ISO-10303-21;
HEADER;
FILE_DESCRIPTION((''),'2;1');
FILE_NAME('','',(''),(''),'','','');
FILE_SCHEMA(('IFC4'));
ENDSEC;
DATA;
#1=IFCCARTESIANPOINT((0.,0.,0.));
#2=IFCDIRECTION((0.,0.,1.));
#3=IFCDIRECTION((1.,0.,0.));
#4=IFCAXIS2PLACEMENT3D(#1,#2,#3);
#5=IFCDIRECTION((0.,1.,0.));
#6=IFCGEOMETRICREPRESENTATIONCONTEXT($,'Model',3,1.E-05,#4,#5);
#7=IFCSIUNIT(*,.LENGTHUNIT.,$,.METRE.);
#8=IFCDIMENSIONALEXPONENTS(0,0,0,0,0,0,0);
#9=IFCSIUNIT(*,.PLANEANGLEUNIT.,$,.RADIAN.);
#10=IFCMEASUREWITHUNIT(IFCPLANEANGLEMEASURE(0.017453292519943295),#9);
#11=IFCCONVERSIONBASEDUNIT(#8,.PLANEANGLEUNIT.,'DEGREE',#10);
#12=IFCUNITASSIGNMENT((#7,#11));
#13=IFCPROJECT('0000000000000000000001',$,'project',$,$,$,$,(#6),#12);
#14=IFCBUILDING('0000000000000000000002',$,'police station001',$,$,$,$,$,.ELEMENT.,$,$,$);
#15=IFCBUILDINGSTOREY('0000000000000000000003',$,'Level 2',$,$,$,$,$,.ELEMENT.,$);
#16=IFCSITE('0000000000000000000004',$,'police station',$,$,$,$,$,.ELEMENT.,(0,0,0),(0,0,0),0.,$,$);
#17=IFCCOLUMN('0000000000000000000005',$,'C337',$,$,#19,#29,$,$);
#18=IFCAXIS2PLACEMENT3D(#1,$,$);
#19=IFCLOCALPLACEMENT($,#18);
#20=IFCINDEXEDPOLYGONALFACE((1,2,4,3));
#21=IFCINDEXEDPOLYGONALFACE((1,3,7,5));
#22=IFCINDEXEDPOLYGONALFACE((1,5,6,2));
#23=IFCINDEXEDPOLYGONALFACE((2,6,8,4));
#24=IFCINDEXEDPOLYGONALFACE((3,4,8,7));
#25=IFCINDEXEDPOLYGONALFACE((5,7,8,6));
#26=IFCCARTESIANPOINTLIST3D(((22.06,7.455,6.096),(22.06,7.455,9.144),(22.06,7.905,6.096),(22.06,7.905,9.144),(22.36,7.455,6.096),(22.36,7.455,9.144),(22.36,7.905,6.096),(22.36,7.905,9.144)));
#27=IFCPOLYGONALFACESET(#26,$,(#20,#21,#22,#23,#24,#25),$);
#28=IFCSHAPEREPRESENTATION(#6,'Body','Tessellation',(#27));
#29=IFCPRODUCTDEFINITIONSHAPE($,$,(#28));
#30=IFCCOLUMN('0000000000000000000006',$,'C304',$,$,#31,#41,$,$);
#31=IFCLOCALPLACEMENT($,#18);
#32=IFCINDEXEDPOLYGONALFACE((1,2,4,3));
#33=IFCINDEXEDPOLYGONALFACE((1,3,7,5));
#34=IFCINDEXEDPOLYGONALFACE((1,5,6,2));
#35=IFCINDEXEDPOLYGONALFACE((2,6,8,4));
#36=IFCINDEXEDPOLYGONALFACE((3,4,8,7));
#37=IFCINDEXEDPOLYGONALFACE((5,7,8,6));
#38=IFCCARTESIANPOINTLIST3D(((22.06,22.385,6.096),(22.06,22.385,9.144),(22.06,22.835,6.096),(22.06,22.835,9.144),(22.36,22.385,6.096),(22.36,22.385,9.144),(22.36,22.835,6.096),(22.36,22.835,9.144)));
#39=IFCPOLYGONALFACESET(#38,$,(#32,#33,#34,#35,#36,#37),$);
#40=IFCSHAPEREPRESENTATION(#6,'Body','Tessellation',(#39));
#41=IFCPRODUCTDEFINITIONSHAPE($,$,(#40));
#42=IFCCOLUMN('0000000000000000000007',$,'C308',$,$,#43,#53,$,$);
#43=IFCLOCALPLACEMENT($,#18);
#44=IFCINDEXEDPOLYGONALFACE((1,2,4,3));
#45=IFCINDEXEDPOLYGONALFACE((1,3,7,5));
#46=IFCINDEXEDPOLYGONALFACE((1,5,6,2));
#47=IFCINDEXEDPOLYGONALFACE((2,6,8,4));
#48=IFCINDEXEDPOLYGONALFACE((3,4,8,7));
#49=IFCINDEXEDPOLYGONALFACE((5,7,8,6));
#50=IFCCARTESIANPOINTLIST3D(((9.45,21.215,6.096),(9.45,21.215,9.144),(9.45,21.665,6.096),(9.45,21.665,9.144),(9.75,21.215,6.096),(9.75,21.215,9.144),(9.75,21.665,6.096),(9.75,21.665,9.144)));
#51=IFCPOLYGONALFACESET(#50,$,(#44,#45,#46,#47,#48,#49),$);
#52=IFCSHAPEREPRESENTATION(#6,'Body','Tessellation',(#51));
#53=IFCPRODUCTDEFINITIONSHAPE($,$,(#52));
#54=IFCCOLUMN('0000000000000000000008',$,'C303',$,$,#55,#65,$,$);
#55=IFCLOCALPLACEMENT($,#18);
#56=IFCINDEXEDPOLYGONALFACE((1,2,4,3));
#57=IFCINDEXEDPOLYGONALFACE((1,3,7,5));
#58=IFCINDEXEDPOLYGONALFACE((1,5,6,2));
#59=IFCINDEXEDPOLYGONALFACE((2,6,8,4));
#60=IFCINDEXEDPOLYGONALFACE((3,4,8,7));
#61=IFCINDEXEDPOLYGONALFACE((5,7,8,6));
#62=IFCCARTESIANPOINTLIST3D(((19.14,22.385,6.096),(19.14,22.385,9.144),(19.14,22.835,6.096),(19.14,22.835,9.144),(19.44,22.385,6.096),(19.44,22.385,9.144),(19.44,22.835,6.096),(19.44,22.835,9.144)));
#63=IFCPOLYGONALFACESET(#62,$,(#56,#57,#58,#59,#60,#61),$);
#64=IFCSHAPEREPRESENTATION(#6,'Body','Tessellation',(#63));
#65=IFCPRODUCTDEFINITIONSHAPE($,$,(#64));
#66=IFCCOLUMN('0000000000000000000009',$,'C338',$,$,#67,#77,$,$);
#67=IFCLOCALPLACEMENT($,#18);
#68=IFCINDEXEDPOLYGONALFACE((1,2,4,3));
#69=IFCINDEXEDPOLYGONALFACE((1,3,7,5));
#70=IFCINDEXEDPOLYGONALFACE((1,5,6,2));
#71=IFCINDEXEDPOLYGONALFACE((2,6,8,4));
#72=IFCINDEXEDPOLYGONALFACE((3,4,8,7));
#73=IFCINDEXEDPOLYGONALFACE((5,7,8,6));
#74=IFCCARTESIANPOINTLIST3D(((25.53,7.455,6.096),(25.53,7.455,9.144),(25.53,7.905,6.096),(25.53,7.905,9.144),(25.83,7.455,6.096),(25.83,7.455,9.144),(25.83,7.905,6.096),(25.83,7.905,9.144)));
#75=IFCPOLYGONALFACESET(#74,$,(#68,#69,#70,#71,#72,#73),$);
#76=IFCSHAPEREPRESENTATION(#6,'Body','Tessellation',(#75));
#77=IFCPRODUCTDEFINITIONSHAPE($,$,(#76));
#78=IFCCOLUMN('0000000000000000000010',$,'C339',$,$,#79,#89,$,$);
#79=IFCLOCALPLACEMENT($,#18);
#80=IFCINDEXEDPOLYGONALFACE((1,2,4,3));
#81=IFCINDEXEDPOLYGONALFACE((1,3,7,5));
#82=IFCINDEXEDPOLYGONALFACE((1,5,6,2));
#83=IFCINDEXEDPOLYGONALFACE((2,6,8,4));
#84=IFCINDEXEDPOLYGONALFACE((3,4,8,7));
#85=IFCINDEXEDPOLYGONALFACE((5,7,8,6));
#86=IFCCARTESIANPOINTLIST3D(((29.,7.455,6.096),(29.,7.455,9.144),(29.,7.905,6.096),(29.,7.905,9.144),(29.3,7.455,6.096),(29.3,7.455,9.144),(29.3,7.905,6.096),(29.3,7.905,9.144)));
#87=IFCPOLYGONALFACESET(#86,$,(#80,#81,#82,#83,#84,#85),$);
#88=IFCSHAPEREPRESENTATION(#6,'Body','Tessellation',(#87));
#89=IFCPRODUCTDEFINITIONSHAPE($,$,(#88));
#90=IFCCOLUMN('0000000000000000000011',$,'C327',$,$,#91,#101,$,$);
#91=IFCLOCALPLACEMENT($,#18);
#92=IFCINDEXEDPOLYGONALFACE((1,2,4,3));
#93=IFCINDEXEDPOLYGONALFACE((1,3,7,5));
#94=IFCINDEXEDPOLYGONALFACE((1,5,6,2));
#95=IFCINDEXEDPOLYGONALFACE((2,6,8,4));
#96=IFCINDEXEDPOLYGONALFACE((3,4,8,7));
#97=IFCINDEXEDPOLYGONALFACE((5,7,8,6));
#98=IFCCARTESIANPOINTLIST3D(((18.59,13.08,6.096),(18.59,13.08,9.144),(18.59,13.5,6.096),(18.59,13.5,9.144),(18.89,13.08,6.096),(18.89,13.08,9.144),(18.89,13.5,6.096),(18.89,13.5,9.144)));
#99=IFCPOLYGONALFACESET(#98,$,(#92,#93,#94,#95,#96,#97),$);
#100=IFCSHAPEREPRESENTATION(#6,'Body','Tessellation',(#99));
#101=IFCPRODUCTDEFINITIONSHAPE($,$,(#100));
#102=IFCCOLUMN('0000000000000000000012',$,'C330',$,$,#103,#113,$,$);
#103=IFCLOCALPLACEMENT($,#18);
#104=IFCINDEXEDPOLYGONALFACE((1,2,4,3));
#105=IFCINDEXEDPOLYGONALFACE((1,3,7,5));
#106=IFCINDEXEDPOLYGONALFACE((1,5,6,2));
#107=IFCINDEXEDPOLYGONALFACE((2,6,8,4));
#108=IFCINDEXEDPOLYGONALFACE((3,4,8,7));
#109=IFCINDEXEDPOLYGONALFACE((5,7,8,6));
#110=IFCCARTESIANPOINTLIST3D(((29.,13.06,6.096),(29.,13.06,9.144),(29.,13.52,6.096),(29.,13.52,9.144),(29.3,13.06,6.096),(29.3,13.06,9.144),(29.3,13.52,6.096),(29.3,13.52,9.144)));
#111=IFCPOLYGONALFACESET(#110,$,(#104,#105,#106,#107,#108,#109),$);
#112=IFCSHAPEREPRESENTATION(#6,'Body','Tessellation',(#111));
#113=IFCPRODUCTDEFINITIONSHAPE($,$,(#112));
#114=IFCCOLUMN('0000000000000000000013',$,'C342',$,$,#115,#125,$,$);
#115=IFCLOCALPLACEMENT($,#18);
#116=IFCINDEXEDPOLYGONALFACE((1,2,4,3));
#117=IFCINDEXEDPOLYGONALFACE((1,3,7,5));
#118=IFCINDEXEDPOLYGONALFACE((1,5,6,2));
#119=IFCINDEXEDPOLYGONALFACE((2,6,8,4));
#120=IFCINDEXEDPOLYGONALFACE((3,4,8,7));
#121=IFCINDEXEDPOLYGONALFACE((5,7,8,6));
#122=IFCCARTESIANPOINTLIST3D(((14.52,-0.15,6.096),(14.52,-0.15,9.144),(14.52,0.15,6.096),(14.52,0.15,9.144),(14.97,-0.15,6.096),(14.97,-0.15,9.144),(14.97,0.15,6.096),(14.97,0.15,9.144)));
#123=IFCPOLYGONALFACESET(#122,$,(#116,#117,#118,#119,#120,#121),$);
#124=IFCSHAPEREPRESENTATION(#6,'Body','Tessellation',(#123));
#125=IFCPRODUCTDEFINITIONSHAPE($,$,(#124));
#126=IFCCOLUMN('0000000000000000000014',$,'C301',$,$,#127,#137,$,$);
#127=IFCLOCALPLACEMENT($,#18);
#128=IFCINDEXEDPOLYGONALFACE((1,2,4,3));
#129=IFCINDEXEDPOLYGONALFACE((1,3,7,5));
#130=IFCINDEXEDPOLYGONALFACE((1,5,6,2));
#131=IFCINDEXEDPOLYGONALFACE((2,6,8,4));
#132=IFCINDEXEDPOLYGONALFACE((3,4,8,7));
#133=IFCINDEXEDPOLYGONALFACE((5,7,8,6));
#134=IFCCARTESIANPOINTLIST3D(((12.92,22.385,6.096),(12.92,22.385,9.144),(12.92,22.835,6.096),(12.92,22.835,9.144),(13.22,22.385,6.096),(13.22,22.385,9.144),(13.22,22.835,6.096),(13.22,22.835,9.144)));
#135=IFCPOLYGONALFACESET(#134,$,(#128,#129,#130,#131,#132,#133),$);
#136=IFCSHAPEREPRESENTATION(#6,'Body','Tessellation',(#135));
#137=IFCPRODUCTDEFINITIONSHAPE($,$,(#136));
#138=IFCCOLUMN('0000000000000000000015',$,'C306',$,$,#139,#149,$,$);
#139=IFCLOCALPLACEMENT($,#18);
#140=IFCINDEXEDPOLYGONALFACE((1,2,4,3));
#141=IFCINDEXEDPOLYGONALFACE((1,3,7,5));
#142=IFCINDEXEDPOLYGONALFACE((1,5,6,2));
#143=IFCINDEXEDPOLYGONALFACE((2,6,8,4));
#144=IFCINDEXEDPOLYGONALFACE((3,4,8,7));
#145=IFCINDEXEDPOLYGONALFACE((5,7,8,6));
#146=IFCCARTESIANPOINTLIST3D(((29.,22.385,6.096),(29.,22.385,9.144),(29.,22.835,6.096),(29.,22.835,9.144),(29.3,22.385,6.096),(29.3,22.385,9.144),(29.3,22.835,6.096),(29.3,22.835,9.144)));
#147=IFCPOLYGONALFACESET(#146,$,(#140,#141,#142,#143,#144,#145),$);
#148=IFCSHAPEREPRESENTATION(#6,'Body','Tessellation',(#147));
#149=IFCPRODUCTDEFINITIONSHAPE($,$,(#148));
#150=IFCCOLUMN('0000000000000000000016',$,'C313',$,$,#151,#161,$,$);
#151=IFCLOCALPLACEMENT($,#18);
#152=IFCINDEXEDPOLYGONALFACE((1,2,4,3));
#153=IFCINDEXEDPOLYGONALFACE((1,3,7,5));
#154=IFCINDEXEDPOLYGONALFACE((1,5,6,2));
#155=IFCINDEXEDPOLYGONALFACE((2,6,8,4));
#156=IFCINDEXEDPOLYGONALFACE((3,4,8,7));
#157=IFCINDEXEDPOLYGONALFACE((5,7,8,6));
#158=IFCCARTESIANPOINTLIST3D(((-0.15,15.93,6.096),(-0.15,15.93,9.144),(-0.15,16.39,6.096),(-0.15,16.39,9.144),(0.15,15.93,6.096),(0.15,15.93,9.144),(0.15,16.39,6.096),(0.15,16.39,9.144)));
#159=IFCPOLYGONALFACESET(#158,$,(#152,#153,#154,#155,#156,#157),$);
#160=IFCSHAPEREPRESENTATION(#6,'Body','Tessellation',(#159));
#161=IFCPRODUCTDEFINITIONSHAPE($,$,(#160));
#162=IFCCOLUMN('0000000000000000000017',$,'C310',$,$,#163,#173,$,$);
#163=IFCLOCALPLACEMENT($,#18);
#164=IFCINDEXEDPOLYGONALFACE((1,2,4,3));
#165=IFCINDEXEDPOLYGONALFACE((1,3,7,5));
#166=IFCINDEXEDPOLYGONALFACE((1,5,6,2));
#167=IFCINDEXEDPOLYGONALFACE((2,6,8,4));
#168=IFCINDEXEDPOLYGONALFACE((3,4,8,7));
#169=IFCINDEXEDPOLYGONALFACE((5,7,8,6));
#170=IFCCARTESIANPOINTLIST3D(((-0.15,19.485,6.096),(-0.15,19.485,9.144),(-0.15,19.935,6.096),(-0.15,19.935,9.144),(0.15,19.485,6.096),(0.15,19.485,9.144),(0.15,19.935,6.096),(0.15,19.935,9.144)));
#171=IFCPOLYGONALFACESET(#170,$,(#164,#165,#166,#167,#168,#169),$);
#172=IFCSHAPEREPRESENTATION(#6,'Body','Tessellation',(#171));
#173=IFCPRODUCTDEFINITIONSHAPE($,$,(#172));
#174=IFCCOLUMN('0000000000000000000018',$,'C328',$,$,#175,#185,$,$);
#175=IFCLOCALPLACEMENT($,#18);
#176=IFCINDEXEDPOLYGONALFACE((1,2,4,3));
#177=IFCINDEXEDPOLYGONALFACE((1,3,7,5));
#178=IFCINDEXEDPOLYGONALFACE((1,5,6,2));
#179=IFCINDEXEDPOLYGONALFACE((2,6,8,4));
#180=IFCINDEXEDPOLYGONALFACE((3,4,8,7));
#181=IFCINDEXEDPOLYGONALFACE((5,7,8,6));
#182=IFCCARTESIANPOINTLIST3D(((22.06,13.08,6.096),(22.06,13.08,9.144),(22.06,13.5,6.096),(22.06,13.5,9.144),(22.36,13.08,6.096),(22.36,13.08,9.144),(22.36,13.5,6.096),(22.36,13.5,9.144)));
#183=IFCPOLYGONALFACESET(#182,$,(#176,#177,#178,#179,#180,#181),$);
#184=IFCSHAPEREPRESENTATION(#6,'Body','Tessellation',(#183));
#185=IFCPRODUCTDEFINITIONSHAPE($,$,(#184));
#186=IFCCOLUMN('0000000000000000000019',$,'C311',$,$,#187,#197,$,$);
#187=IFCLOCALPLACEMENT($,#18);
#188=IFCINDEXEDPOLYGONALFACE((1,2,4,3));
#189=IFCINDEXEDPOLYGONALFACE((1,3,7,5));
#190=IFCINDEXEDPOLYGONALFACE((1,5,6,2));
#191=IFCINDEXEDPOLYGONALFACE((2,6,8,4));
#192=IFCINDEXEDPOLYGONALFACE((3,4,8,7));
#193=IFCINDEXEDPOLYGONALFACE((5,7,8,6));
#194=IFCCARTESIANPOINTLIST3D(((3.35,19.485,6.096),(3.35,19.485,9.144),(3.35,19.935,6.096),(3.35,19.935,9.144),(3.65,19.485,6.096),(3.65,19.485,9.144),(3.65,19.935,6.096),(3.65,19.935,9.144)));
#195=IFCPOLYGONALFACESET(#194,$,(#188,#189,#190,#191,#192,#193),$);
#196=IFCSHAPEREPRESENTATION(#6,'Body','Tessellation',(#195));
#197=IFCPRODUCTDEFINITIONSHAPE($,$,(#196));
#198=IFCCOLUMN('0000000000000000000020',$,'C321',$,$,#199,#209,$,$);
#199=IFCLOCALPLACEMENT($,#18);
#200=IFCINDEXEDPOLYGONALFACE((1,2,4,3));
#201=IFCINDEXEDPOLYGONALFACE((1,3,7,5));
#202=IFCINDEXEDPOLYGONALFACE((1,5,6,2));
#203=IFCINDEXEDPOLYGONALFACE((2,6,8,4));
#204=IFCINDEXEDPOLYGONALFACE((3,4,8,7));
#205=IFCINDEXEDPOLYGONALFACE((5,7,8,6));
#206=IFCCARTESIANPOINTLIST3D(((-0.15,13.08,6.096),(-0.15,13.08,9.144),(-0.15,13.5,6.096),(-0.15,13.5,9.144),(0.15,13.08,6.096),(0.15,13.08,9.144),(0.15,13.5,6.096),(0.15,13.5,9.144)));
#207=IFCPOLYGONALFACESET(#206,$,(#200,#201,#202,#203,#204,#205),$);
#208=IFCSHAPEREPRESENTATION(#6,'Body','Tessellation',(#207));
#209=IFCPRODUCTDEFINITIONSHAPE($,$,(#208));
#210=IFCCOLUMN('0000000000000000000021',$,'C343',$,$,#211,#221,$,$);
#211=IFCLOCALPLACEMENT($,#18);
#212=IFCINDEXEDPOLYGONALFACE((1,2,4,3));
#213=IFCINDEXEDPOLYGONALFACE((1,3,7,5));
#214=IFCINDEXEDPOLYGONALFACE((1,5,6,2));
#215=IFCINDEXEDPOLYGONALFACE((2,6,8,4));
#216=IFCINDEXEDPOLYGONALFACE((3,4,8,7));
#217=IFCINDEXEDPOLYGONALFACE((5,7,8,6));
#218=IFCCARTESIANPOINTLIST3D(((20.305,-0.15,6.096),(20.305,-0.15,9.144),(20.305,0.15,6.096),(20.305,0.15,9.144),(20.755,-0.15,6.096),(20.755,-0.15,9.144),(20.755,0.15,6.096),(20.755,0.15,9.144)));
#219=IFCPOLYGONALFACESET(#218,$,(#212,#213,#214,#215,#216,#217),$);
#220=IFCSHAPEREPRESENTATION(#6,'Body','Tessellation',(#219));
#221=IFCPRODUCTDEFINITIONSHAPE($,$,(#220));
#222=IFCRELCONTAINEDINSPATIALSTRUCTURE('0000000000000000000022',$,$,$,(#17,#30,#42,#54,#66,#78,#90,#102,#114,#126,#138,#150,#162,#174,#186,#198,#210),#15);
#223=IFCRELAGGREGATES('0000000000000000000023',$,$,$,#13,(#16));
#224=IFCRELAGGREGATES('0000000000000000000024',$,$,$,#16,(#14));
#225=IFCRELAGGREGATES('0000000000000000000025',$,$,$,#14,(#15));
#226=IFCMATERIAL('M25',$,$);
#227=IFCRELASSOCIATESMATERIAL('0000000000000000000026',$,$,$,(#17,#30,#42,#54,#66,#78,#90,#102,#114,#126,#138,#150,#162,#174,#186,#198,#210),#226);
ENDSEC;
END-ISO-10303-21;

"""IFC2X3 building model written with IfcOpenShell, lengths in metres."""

from ifc_helpers import new_model, entity, si_unit, converted_unit, direction, frame, frame_2d, origin_with_axes, place, context, project, spatial, rectangle, extrude, material, element, save


model = new_model("IFC2X3")

# Units and contexts
model_context = context("Model", 3, precision=1e-05, world=origin_with_axes(), true_north=direction((0.0, 1.0, 0.0)))
ifc_project = project(units=[si_unit("LENGTHUNIT", "METRE"), converted_unit("PLANEANGLEUNIT", "DEGREE", entity("IfcPlaneAngleMeasure", 0.017453292519943295), si_unit("PLANEANGLEUNIT", "RADIAN"), dimensions=[0, 0, 0, 0, 0, 0, 0])], contexts=[model_context])

# Site, building, storey
site = spatial("IfcSite", under=ifc_project, Name="police station", CompositionType="ELEMENT", RefLatitude=(0, 0, 0), RefLongitude=(0, 0, 0), RefElevation=0.0)
building = spatial("IfcBuilding", under=site, Name="police station001", CompositionType="ELEMENT")
storey = spatial("IfcBuildingStorey", under=building, Name="Level 2", CompositionType="ELEMENT")

# Columns
ifc_material = material(Name="M25")
placement = place(None, origin_with_axes())
element("IfcColumn", 1, at=placement, inside=storey, material=ifc_material, Name="C337", context=model_context, shape_type="SweptSolid", body=[
    extrude(rectangle(XDim=0.3, YDim=0.45, at=frame_2d((0.0, 0.0), x_axis=(1.0, 0.0, 0.0))), frame((22.21, 7.68, 6.096), z_axis=(0.0, 0.0, 1.0), x_axis=(1.0, 0.0, 0.0)), (0.0, 0.0, 1.0), 3.048),
])
element("IfcColumn", 2, at=placement, inside=storey, material=ifc_material, Name="C304", context=model_context, shape_type="SweptSolid", body=[
    extrude(rectangle(XDim=0.3, YDim=0.45, at=frame_2d((0.0, 0.0), x_axis=(1.0, 0.0, 0.0))), frame((22.21, 22.61, 6.096), z_axis=(0.0, 0.0, 1.0), x_axis=(1.0, 0.0, 0.0)), (0.0, 0.0, 1.0), 3.048),
])
element("IfcColumn", 3, at=placement, inside=storey, material=ifc_material, Name="C308", context=model_context, shape_type="SweptSolid", body=[
    extrude(rectangle(XDim=0.3, YDim=0.45, at=frame_2d((0.0, 0.0), x_axis=(1.0, 0.0, 0.0))), frame((9.6, 21.44, 6.096), z_axis=(0.0, 0.0, 1.0), x_axis=(1.0, 0.0, 0.0)), (0.0, 0.0, 1.0), 3.048),
])
element("IfcColumn", 4, at=placement, inside=storey, material=ifc_material, Name="C303", context=model_context, shape_type="SweptSolid", body=[
    extrude(rectangle(XDim=0.3, YDim=0.45, at=frame_2d((0.0, 0.0), x_axis=(1.0, 0.0, 0.0))), frame((19.29, 22.61, 6.096), z_axis=(0.0, 0.0, 1.0), x_axis=(1.0, 0.0, 0.0)), (0.0, 0.0, 1.0), 3.048),
])
element("IfcColumn", 5, at=placement, inside=storey, material=ifc_material, Name="C338", context=model_context, shape_type="SweptSolid", body=[
    extrude(rectangle(XDim=0.3, YDim=0.45, at=frame_2d((0.0, 0.0), x_axis=(1.0, 0.0, 0.0))), frame((25.68, 7.68, 6.096), z_axis=(0.0, 0.0, 1.0), x_axis=(1.0, 0.0, 0.0)), (0.0, 0.0, 1.0), 3.048),
])
element("IfcColumn", 6, at=placement, inside=storey, material=ifc_material, Name="C339", context=model_context, shape_type="SweptSolid", body=[
    extrude(rectangle(XDim=0.3, YDim=0.45, at=frame_2d((0.0, 0.0), x_axis=(1.0, 0.0, 0.0))), frame((29.15, 7.68, 6.096), z_axis=(0.0, 0.0, 1.0), x_axis=(1.0, 0.0, 0.0)), (0.0, 0.0, 1.0), 3.048),
])
element("IfcColumn", 7, at=placement, inside=storey, material=ifc_material, Name="C327", context=model_context, shape_type="SweptSolid", body=[
    extrude(rectangle(XDim=0.3, YDim=0.42, at=frame_2d((0.0, 0.0), x_axis=(1.0, 0.0, 0.0))), frame((18.74, 13.29, 6.096), z_axis=(0.0, 0.0, 1.0), x_axis=(1.0, 0.0, 0.0)), (0.0, 0.0, 1.0), 3.048),
])
element("IfcColumn", 8, at=placement, inside=storey, material=ifc_material, Name="C330", context=model_context, shape_type="SweptSolid", body=[
    extrude(rectangle(XDim=0.3, YDim=0.46, at=frame_2d((0.0, 0.0), x_axis=(1.0, 0.0, 0.0))), frame((29.15, 13.29, 6.096), z_axis=(0.0, 0.0, 1.0), x_axis=(1.0, 0.0, 0.0)), (0.0, 0.0, 1.0), 3.048),
])
element("IfcColumn", 9, at=placement, inside=storey, material=ifc_material, Name="C342", context=model_context, shape_type="SweptSolid", body=[
    extrude(rectangle(XDim=0.45, YDim=0.3, at=frame_2d((0.0, 0.0), x_axis=(1.0, 0.0, 0.0))), frame((14.745, 0.0, 6.096), z_axis=(0.0, 0.0, 1.0), x_axis=(1.0, 0.0, 0.0)), (0.0, 0.0, 1.0), 3.048),
])
element("IfcColumn", 10, at=placement, inside=storey, material=ifc_material, Name="C301", context=model_context, shape_type="SweptSolid", body=[
    extrude(rectangle(XDim=0.3, YDim=0.45, at=frame_2d((0.0, 0.0), x_axis=(1.0, 0.0, 0.0))), frame((13.07, 22.61, 6.096), z_axis=(0.0, 0.0, 1.0), x_axis=(1.0, 0.0, 0.0)), (0.0, 0.0, 1.0), 3.048),
])
element("IfcColumn", 11, at=placement, inside=storey, material=ifc_material, Name="C306", context=model_context, shape_type="SweptSolid", body=[
    extrude(rectangle(XDim=0.3, YDim=0.45, at=frame_2d((0.0, 0.0), x_axis=(1.0, 0.0, 0.0))), frame((29.15, 22.61, 6.096), z_axis=(0.0, 0.0, 1.0), x_axis=(1.0, 0.0, 0.0)), (0.0, 0.0, 1.0), 3.048),
])
element("IfcColumn", 12, at=placement, inside=storey, material=ifc_material, Name="C313", context=model_context, shape_type="SweptSolid", body=[
    extrude(rectangle(XDim=0.3, YDim=0.46, at=frame_2d((0.0, 0.0), x_axis=(1.0, 0.0, 0.0))), frame((0.0, 16.16, 6.096), z_axis=(0.0, 0.0, 1.0), x_axis=(1.0, 0.0, 0.0)), (0.0, 0.0, 1.0), 3.048),
])
element("IfcColumn", 13, at=placement, inside=storey, material=ifc_material, Name="C310", context=model_context, shape_type="SweptSolid", body=[
    extrude(rectangle(XDim=0.3, YDim=0.45, at=frame_2d((0.0, 0.0), x_axis=(1.0, 0.0, 0.0))), frame((0.0, 19.71, 6.096), z_axis=(0.0, 0.0, 1.0), x_axis=(1.0, 0.0, 0.0)), (0.0, 0.0, 1.0), 3.048),
])
element("IfcColumn", 14, at=placement, inside=storey, material=ifc_material, Name="C328", context=model_context, shape_type="SweptSolid", body=[
    extrude(rectangle(XDim=0.3, YDim=0.42, at=frame_2d((0.0, 0.0), x_axis=(1.0, 0.0, 0.0))), frame((22.21, 13.29, 6.096), z_axis=(0.0, 0.0, 1.0), x_axis=(1.0, 0.0, 0.0)), (0.0, 0.0, 1.0), 3.048),
])
element("IfcColumn", 15, at=placement, inside=storey, material=ifc_material, Name="C311", context=model_context, shape_type="SweptSolid", body=[
    extrude(rectangle(XDim=0.3, YDim=0.45, at=frame_2d((0.0, 0.0), x_axis=(1.0, 0.0, 0.0))), frame((3.5, 19.71, 6.096), z_axis=(0.0, 0.0, 1.0), x_axis=(1.0, 0.0, 0.0)), (0.0, 0.0, 1.0), 3.048),
])
element("IfcColumn", 16, at=placement, inside=storey, material=ifc_material, Name="C321", context=model_context, shape_type="SweptSolid", body=[
    extrude(rectangle(XDim=0.3, YDim=0.42, at=frame_2d((0.0, 0.0), x_axis=(1.0, 0.0, 0.0))), frame((0.0, 13.29, 6.096), z_axis=(0.0, 0.0, 1.0), x_axis=(1.0, 0.0, 0.0)), (0.0, 0.0, 1.0), 3.048),
])
element("IfcColumn", 17, at=placement, inside=storey, material=ifc_material, Name="C343", context=model_context, shape_type="SweptSolid", body=[
    extrude(rectangle(XDim=0.45, YDim=0.3, at=frame_2d((0.0, 0.0), x_axis=(1.0, 0.0, 0.0))), frame((20.53, 0.0, 6.096), z_axis=(0.0, 0.0, 1.0), x_axis=(1.0, 0.0, 0.0)), (0.0, 0.0, 1.0), 3.048),
])

save(model, "model.ifc")
